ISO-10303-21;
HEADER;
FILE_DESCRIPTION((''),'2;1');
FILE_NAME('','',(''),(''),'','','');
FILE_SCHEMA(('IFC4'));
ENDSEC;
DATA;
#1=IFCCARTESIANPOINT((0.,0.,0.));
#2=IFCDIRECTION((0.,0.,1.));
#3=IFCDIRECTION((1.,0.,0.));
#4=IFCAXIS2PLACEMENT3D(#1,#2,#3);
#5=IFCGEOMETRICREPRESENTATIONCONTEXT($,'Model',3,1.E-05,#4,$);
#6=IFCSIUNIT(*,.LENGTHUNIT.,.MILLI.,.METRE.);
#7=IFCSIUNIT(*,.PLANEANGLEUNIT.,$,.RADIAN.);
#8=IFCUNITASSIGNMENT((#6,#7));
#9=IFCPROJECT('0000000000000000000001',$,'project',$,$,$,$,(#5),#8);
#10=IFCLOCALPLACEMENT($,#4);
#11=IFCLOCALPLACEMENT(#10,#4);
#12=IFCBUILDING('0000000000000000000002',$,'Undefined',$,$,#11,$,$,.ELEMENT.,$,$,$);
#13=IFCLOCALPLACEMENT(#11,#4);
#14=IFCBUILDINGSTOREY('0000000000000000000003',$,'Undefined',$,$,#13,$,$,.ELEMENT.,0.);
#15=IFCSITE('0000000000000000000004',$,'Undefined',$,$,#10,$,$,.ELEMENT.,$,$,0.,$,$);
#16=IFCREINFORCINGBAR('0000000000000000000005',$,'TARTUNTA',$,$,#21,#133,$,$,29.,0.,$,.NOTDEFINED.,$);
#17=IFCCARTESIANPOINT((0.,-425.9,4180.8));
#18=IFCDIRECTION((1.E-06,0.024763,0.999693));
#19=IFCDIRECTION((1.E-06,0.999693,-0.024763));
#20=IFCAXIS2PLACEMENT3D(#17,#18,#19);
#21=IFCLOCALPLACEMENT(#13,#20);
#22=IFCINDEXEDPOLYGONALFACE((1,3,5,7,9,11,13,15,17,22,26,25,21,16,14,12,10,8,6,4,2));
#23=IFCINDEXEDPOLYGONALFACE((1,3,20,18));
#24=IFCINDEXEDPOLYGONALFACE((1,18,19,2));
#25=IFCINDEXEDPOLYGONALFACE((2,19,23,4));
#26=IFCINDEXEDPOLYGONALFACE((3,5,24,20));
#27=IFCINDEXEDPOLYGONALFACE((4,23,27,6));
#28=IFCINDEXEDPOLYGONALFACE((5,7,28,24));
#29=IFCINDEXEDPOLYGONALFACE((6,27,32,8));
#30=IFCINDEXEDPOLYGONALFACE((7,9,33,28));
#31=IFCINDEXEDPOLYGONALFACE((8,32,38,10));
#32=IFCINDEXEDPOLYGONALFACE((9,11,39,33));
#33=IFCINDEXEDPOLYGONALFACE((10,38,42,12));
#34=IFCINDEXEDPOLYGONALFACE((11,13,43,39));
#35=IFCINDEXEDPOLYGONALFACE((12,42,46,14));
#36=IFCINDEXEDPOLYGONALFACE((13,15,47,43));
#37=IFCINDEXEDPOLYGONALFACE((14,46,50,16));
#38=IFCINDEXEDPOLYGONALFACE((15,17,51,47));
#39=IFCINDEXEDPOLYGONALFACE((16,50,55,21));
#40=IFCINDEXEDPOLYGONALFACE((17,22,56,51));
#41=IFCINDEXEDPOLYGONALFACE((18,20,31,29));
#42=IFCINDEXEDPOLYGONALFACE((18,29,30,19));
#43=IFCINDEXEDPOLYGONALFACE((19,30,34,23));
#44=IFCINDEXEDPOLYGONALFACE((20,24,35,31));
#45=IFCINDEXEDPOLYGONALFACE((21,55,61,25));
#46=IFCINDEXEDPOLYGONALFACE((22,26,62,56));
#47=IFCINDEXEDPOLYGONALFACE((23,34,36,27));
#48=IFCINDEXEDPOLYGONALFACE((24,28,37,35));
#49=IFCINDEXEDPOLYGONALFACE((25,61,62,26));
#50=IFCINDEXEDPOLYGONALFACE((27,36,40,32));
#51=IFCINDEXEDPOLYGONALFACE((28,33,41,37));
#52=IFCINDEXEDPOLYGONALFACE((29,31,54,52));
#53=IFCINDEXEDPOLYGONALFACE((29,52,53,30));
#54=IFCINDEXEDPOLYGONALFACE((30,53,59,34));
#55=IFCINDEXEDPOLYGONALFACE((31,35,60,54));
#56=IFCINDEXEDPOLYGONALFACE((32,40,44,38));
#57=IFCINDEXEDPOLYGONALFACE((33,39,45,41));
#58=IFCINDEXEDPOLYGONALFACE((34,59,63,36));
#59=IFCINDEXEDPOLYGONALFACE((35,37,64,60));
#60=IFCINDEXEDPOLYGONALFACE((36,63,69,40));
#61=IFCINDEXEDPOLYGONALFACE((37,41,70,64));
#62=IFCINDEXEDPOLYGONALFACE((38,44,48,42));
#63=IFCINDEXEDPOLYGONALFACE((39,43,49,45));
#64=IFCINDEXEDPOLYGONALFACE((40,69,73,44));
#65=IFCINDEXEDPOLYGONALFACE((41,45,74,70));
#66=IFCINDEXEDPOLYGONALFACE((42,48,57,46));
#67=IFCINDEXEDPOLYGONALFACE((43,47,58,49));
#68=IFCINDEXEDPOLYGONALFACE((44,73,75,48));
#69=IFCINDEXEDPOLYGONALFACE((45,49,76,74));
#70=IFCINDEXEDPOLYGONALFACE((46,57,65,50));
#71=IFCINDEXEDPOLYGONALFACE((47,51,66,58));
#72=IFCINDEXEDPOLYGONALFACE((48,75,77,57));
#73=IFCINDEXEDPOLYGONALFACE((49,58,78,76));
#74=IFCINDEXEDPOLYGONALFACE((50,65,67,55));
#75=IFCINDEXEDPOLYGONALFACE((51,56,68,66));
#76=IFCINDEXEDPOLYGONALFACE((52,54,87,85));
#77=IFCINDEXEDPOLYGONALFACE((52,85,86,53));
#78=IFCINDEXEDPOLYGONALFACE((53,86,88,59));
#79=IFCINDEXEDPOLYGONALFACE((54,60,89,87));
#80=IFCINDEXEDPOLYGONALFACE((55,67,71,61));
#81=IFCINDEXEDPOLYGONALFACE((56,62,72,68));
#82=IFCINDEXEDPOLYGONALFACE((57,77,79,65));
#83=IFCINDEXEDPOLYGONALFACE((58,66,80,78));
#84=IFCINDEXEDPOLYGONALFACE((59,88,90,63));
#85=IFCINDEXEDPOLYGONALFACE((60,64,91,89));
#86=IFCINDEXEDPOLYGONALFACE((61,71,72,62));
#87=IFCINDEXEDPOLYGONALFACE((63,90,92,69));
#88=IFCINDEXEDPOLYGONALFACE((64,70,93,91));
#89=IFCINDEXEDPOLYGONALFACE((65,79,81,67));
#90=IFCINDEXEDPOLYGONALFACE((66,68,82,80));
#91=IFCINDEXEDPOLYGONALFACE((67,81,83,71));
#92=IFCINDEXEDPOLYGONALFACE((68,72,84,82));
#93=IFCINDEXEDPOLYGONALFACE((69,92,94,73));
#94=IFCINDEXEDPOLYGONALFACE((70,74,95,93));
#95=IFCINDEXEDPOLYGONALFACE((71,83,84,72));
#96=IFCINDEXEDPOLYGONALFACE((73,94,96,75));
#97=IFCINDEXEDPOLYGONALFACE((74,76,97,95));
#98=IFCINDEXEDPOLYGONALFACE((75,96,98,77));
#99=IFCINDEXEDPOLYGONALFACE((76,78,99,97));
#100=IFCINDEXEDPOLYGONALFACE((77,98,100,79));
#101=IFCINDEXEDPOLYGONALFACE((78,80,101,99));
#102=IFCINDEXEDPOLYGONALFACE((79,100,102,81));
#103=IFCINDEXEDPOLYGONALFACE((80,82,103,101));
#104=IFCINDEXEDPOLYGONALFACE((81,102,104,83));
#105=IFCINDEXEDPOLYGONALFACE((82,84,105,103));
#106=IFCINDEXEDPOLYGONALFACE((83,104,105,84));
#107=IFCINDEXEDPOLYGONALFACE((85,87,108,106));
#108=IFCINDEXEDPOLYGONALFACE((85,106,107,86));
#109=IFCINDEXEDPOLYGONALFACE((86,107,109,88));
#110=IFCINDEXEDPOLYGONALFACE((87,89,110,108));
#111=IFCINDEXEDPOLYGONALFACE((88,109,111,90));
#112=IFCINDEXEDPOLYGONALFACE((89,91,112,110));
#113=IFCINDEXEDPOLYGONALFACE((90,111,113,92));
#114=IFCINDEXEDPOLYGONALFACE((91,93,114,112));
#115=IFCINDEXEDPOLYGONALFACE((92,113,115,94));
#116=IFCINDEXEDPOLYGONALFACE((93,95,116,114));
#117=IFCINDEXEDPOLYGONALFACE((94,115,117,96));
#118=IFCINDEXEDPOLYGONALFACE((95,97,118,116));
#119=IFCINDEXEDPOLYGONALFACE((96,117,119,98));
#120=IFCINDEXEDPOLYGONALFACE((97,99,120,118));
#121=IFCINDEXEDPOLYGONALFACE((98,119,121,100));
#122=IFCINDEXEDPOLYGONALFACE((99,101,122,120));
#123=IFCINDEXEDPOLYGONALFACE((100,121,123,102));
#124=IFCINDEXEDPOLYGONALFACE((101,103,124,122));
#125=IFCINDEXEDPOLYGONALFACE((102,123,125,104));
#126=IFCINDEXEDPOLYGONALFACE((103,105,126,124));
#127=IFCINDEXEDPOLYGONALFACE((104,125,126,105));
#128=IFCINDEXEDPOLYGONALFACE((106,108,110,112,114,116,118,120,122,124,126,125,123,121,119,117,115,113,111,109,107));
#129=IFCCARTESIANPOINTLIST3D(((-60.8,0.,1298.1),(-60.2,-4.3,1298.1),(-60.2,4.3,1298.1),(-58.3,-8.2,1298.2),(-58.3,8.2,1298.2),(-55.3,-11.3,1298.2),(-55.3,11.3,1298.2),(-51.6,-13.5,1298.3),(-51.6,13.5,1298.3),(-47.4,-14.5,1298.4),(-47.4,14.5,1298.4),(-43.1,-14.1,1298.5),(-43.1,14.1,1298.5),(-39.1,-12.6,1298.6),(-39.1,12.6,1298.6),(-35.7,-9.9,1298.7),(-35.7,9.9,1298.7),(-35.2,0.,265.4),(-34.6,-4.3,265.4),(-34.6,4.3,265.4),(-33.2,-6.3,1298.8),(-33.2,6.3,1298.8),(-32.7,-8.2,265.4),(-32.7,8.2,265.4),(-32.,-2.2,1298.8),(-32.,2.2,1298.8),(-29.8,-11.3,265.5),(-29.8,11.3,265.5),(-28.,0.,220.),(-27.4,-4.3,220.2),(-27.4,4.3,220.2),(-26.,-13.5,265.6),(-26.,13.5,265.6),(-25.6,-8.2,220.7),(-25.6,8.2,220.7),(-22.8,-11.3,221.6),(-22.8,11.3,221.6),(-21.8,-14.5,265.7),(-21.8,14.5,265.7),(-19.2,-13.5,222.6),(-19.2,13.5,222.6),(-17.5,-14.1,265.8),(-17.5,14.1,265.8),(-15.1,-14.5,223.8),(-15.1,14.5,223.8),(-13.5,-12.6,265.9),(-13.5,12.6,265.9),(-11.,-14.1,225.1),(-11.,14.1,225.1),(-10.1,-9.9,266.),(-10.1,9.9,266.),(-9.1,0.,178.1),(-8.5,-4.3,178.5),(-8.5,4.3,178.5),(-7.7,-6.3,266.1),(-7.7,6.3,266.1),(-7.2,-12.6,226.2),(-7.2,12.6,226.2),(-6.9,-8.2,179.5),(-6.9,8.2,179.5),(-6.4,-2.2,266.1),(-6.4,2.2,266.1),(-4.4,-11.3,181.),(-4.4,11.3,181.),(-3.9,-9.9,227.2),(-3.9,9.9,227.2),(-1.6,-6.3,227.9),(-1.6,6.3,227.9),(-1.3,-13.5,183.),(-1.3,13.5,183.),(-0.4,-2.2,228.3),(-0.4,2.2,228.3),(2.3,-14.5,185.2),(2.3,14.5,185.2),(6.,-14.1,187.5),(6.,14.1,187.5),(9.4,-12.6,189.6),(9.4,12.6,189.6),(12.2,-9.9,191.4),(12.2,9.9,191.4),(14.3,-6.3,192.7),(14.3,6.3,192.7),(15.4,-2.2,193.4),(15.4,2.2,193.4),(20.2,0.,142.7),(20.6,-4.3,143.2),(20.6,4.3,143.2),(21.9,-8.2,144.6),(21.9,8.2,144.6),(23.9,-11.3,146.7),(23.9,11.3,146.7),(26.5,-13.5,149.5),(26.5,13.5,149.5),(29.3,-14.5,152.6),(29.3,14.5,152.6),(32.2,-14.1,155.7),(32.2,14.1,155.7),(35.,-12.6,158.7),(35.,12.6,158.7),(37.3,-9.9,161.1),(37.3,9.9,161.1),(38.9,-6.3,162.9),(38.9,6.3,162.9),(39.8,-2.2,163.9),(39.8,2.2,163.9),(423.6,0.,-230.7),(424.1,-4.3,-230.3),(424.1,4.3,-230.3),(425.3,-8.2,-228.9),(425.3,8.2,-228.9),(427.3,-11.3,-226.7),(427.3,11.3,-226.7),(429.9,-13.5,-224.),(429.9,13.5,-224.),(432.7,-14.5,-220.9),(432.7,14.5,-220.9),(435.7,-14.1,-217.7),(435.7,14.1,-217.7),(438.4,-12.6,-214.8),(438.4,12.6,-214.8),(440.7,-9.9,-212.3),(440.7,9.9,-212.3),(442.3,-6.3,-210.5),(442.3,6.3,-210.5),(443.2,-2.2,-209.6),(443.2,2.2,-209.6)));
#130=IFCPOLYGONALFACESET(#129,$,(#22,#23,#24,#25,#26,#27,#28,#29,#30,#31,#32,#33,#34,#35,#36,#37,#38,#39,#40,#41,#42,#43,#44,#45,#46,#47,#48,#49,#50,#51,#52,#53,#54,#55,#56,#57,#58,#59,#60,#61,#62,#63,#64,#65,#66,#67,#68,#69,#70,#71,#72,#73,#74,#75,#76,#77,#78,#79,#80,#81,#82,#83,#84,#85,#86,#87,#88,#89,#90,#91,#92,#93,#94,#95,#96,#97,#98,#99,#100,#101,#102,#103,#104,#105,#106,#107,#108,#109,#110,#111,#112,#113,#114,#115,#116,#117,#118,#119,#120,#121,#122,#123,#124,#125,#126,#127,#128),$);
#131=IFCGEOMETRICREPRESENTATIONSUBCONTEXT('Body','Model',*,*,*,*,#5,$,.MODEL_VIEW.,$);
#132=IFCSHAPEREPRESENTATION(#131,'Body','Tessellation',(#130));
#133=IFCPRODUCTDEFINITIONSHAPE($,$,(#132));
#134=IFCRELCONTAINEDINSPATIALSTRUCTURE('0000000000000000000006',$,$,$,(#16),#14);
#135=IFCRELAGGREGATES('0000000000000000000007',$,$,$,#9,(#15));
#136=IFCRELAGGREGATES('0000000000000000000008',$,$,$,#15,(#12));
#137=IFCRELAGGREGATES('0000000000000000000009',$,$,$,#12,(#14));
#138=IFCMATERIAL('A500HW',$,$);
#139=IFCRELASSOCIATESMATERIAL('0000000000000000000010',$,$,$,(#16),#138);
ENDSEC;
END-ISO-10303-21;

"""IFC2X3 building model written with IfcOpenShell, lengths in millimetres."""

from ifc_helpers import new_model, entity, si_unit, frame, origin_with_axes, place, context, subcontext, project, spatial, source, transform, mapped, material, element, save


model = new_model("IFC2X3")

# Units and contexts
model_context = context("Model", 3, precision=1e-05, world=origin_with_axes())
body_context = subcontext(model_context, "Body", "Model", "MODEL_VIEW")
ifc_project = project(units=[si_unit("LENGTHUNIT", "METRE", prefix="MILLI"), si_unit("PLANEANGLEUNIT", "RADIAN")], contexts=[model_context])

# Site, building, storey
site_placement = place(None, origin_with_axes())
site = spatial("IfcSite", under=ifc_project, at=site_placement, Name="Undefined", CompositionType="ELEMENT", RefElevation=0.0)
building_placement = place(site_placement, origin_with_axes())
building = spatial("IfcBuilding", under=site, at=building_placement, Name="Undefined", CompositionType="ELEMENT")
storey_placement = place(building_placement, origin_with_axes())
storey = spatial("IfcBuildingStorey", under=building, at=storey_placement, Name="Undefined", CompositionType="ELEMENT", Elevation=0.0)

# Reinforcing bar
ifc_material_1 = material(Name="A500HW")
shared_shape_1 = source(origin_with_axes(), body_context, "Body", "AdvancedSweptSolid", [
    entity("IfcSweptDiskSolid", entity("IfcCompositeCurve", [entity("IfcCompositeCurveSegment", "CONTINUOUS", True, entity("IfcTrimmedCurve", entity("IfcLine", entity("IfcCartesianPoint", [0.0, 0.0, 0.0]), entity("IfcVector", entity("IfcDirection", [0.024764, 0.0, -0.999693]), 1.0)), [entity("IfcParameterValue", 0.0)], [entity("IfcParameterValue", 1033.051648)], True, "PARAMETER")), entity("IfcCompositeCurveSegment", "CONTINUOUS", True, entity("IfcTrimmedCurve", entity("IfcCircle", entity("IfcAxis2Placement3D", entity("IfcCartesianPoint", [184.0, 0.0, -1028.8]), entity("IfcDirection", [-0.000002, -1.0, 0.0]), entity("IfcDirection", [-0.999693, 0.000002, -0.024764])), 158.5), [entity("IfcParameterValue", 0.0)], [entity("IfcParameterValue", 0.799175)], True, "PARAMETER")), entity("IfcCompositeCurveSegment", "DISCONTINUOUS", True, entity("IfcTrimmedCurve", entity("IfcLine", entity("IfcCartesianPoint", [76.4, 0.0, -1145.1]), entity("IfcVector", entity("IfcDirection", [0.733829, -0.000001, -0.679334]), 1.0)), [entity("IfcParameterValue", 0.0)], [entity("IfcParameterValue", 549.736541)], True, "PARAMETER"))], False), 14.5, None, 0.0, 1583.6),
])
reinforcing_bar_1_placement = place(storey_placement, frame((0.0, -425.9, 4180.8), z_axis=(0.000001, 0.024763, 0.999693), x_axis=(0.000001, 0.999693, -0.024763)))
element("IfcReinforcingBar", 1, at=reinforcing_bar_1_placement, inside=storey, material=ifc_material_1, Name="TARTUNTA", BarRole="NOTDEFINED", CrossSectionArea=0.0, NominalDiameter=29.0, context=body_context, shape_type="MappedRepresentation", body=[
    mapped(shared_shape_1, transform((-46.3, 0.0, 1298.5))),
])

save(model, "model.ifc")
